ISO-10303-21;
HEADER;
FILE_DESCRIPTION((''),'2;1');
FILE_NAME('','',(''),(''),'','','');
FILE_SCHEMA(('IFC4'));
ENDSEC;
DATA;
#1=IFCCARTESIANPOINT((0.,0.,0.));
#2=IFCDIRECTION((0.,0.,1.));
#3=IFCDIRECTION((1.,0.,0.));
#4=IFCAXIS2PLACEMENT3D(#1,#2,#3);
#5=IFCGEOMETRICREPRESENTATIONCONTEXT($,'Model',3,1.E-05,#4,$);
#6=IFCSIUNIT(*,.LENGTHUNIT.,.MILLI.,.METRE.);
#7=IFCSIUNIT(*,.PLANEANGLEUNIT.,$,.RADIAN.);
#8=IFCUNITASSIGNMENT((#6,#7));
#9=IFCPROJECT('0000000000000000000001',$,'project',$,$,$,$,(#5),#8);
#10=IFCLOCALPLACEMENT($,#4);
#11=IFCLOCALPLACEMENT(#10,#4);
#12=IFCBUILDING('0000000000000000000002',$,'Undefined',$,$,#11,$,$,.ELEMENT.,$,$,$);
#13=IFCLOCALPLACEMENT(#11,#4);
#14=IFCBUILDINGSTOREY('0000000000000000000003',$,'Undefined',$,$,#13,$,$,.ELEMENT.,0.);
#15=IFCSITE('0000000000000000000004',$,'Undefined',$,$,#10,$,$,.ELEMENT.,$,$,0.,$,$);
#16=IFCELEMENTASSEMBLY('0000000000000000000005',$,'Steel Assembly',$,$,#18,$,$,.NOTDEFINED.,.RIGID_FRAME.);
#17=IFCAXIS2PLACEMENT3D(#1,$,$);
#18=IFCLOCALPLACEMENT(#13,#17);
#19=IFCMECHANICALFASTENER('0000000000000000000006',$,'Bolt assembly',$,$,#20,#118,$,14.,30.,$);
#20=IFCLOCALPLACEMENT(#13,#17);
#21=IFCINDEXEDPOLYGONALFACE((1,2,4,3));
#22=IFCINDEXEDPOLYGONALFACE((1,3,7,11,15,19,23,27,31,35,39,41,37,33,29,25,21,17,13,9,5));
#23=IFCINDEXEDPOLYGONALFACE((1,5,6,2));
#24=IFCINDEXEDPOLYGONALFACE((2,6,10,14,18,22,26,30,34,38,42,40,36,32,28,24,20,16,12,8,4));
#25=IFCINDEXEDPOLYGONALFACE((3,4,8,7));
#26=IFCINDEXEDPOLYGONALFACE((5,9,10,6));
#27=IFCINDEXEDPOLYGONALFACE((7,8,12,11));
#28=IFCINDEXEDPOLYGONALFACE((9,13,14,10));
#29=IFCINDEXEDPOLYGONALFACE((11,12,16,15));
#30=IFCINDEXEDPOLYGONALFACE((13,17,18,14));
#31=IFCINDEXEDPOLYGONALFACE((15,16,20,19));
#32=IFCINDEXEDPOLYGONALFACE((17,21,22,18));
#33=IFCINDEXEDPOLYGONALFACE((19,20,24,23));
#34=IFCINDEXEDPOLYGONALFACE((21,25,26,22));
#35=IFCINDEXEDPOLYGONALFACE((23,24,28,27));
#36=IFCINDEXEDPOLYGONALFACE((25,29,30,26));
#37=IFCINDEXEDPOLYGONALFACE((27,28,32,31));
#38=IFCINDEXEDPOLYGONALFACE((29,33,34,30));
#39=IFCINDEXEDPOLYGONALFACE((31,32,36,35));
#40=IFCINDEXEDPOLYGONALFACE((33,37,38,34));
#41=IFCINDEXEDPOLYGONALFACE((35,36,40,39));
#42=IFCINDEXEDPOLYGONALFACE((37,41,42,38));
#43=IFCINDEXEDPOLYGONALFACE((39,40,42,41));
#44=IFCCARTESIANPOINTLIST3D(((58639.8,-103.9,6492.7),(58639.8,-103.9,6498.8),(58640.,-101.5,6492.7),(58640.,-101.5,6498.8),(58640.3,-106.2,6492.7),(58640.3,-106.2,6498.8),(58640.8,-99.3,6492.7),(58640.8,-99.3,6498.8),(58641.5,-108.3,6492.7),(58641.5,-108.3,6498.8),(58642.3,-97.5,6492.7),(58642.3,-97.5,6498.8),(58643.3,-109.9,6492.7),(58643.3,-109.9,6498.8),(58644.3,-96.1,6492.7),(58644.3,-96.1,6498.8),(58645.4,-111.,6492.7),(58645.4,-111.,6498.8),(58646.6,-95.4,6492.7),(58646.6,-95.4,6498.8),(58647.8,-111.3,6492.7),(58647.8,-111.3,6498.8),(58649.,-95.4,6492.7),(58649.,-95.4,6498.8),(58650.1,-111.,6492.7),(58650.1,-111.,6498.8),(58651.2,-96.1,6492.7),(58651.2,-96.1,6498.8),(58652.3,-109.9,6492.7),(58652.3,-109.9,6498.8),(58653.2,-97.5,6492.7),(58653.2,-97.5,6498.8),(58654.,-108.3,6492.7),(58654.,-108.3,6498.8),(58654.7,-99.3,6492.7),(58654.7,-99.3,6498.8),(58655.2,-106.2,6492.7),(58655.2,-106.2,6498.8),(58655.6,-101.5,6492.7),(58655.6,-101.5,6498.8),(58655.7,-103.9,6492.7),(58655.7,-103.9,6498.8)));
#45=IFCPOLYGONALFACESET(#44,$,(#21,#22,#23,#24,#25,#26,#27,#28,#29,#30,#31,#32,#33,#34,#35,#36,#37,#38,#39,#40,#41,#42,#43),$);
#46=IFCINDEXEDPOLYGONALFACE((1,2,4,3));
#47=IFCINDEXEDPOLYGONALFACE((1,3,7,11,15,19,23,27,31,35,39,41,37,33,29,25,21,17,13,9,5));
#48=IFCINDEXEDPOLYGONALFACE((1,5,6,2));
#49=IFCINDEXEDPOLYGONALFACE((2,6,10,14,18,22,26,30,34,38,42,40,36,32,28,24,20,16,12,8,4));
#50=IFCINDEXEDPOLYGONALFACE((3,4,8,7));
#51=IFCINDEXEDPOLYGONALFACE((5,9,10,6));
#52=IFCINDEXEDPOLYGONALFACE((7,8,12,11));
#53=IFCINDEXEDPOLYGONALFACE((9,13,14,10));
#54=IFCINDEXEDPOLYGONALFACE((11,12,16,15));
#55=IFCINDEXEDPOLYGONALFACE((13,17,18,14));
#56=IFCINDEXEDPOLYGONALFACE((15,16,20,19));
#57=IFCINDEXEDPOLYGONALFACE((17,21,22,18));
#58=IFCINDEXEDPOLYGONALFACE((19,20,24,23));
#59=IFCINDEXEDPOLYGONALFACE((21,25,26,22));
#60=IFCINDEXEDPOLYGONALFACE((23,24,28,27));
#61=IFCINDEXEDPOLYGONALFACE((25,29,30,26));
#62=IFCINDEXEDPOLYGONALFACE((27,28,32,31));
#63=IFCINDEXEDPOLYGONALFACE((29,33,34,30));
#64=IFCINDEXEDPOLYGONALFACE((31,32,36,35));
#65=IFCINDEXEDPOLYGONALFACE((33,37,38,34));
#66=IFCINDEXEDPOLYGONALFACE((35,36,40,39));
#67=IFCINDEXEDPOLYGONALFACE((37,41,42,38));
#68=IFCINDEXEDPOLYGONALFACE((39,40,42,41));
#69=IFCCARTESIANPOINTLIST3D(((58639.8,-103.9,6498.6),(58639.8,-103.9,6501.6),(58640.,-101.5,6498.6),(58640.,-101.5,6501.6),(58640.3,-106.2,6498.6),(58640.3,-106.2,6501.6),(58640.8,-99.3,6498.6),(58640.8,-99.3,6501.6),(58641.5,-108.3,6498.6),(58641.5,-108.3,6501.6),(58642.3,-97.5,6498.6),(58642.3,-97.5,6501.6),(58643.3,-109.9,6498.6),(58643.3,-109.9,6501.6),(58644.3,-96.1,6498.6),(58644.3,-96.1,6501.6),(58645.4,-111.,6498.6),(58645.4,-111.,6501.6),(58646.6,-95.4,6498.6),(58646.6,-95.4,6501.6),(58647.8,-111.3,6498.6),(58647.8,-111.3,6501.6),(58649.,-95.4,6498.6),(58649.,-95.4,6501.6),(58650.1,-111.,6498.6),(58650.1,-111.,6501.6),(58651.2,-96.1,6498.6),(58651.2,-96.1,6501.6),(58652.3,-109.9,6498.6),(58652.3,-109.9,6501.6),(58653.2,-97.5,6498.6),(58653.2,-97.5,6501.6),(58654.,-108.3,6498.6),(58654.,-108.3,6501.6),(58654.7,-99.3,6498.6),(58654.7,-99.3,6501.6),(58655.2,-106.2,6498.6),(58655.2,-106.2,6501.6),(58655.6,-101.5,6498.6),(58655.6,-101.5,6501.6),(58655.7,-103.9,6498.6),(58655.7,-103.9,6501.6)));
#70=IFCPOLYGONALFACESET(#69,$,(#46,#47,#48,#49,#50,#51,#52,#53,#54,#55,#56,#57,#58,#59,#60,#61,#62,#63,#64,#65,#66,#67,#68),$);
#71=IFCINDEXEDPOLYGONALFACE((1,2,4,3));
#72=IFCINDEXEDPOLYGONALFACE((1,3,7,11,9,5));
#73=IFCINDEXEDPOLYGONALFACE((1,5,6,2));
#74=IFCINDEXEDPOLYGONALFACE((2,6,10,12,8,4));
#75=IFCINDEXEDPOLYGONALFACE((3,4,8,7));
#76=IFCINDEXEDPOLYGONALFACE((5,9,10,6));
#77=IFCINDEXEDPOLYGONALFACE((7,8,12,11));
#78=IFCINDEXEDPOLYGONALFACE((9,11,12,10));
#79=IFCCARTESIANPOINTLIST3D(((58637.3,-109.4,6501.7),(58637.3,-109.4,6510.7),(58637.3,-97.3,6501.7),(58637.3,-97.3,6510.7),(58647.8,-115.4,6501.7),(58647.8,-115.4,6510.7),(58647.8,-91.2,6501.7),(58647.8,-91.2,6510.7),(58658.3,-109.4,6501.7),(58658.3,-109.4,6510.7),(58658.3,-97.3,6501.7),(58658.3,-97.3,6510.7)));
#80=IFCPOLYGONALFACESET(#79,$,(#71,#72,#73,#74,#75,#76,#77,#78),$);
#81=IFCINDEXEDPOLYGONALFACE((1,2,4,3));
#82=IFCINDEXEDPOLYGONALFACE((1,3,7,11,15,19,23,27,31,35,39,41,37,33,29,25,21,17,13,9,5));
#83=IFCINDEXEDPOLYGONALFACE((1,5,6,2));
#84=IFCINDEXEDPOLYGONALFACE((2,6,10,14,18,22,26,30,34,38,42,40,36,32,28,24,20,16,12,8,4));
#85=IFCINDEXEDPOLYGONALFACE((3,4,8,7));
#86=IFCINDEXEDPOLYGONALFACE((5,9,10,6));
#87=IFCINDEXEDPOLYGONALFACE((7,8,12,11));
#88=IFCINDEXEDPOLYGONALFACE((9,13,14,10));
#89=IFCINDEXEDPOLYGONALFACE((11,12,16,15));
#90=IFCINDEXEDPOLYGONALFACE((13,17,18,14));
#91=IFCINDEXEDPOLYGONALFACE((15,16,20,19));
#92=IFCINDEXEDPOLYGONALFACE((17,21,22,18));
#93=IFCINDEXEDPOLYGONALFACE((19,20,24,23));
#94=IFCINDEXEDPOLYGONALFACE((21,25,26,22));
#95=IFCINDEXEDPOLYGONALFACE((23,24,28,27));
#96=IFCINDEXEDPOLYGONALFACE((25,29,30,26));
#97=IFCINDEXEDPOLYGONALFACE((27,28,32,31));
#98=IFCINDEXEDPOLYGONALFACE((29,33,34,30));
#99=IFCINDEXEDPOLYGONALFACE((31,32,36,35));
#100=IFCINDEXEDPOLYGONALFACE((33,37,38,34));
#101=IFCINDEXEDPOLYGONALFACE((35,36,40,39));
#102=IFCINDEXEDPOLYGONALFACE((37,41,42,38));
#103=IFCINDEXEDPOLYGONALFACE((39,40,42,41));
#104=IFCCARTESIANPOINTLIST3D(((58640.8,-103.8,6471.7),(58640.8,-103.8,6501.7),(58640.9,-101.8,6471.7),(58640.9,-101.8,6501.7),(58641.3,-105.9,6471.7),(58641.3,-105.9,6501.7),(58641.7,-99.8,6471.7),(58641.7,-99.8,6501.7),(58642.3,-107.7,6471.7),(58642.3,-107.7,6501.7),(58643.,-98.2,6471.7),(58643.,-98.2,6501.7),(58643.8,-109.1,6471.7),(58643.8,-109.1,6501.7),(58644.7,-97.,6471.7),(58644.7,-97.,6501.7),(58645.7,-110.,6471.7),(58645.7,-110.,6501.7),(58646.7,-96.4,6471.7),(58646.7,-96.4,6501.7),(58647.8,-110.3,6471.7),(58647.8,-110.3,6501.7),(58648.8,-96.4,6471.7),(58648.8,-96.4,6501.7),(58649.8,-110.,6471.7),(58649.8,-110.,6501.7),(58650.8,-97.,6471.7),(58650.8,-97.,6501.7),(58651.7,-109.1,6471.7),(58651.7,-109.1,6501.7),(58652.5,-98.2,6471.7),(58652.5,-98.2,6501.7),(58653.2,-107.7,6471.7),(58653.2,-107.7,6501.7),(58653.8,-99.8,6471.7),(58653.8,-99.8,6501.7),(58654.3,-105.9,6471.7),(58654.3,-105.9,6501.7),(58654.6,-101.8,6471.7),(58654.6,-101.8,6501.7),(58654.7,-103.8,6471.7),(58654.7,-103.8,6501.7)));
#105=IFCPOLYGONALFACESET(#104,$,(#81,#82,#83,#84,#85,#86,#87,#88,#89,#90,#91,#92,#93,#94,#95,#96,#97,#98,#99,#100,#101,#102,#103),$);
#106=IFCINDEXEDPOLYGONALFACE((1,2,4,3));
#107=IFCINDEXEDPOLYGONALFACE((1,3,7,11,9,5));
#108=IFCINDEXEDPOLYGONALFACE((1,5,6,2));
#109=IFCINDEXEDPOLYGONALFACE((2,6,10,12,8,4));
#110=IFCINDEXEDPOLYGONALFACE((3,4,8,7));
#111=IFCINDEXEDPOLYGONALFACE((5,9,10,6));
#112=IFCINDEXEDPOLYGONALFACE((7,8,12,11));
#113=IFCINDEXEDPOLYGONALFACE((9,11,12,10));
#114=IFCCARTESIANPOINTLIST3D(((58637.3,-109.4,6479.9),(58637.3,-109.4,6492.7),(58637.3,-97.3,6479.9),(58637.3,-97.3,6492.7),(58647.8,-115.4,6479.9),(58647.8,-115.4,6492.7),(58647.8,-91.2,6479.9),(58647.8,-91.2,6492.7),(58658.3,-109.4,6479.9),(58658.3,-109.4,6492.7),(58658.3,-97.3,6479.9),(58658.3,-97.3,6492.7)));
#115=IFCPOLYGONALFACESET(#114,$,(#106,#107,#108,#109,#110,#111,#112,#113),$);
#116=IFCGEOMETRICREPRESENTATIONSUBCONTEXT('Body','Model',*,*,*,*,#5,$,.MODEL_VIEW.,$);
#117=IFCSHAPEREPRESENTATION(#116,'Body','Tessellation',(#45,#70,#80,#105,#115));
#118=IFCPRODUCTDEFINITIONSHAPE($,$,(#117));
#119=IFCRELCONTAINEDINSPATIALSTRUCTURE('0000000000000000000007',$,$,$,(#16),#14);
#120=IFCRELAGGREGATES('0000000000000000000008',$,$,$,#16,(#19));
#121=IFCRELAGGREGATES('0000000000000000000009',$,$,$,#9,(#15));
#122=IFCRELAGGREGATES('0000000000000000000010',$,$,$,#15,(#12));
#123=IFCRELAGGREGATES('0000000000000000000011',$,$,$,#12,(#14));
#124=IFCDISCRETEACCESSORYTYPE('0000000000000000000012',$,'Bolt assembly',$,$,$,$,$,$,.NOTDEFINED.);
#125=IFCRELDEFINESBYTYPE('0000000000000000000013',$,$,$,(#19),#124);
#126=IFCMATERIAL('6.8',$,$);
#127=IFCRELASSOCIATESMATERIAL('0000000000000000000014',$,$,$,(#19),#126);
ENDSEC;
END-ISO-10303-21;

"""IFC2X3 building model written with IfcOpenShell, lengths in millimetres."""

from ifc_helpers import new_model, si_unit, frame, origin_with_axes, origin_2d_with_axis, place, context, subcontext, project, spatial, polyline, circle, outline, extrude, source, transform, mapped, material, type_object, element, aggregate, save


model = new_model("IFC2X3")

# Units and contexts
model_context = context("Model", 3, precision=1e-05, world=origin_with_axes())
body_context = subcontext(model_context, "Body", "Model", "MODEL_VIEW")
ifc_project = project(units=[si_unit("LENGTHUNIT", "METRE", prefix="MILLI"), si_unit("PLANEANGLEUNIT", "RADIAN")], contexts=[model_context])

# Site, building, storey
site_placement = place(None, origin_with_axes())
site = spatial("IfcSite", under=ifc_project, at=site_placement, Name="Undefined", CompositionType="ELEMENT", RefElevation=0.0)
building_placement = place(site_placement, origin_with_axes())
building = spatial("IfcBuilding", under=site, at=building_placement, Name="Undefined", CompositionType="ELEMENT")
storey_placement = place(building_placement, origin_with_axes())
storey = spatial("IfcBuildingStorey", under=building, at=storey_placement, Name="Undefined", CompositionType="ELEMENT", Elevation=0.0)

# Element assembly
assembly_1_placement = place(storey_placement, origin_with_axes())
assembly_1 = element("IfcElementAssembly", 1, at=assembly_1_placement, inside=storey, Name="Steel Assembly", AssemblyPlace="NOTDEFINED", PredefinedType="RIGID_FRAME")

# Shared definitions
ifc_material_1 = material(Name="6.8")
discrete_accessory_type_1 = type_object("IfcDiscreteAccessoryType", Name="Bolt assembly")

# Mechanical fastener
shared_shape_1 = source(origin_with_axes(), body_context, "Body", "SweptSolid", [
    extrude(circle(Radius=8.0, at=origin_2d_with_axis()), frame((0.0, -0.1, 0.0), z_axis=(0.0, 1.0, 0.0), x_axis=(1.0, 0.0, 0.0)), (0.0, 0.0, 1.0), 6.1),
    extrude(circle(Radius=8.0, at=origin_2d_with_axis()), frame((0.0, -2.9, 0.0), z_axis=(0.0, 1.0, 0.0), x_axis=(1.0, 0.0, 0.0)), (0.0, 0.0, 1.0), 3.0),
    extrude(outline(polyline([(12.1, 0.0), (6.1, 10.5), (-6.1, 10.5), (-12.1, 0.0), (-6.1, -10.5), (6.1, -10.5), (12.1, 0.0)])), frame((0.0, -12.0, 0.0), z_axis=(0.0, 1.0, 0.0), x_axis=(1.0, 0.0, 0.0)), (0.0, 0.0, 1.0), 9.0),
    extrude(circle(Radius=7.0, at=origin_2d_with_axis()), frame((0.0, -3.0, 0.0), z_axis=(0.0, 1.0, 0.0), x_axis=(1.0, 0.0, 0.0)), (0.0, 0.0, 1.0), 30.0),
    extrude(outline(polyline([(12.1, 0.0), (6.1, 10.5), (-6.1, 10.5), (-12.1, 0.0), (-6.1, -10.5), (6.1, -10.5), (12.1, 0.0)])), frame((0.0, 6.0, 0.0), z_axis=(0.0, 1.0, 0.0), x_axis=(1.0, 0.0, 0.0)), (0.0, 0.0, 1.0), 12.8),
])
mechanical_fastener_1_placement = place(assembly_1_placement, frame((58647.8, -103.3, 6498.7), z_axis=(1.0, 0.0, 0.0), x_axis=(0.0, -1.0, 0.0)))
mechanical_fastener_1 = element("IfcMechanicalFastener", 2, at=mechanical_fastener_1_placement, type_object=discrete_accessory_type_1, material=ifc_material_1, Name="Bolt assembly", NominalDiameter=14.0, NominalLength=30.0, context=body_context, shape_type="MappedRepresentation", body=[
    mapped(shared_shape_1, transform((0.0, 0.0, 0.0))),
])
aggregate(assembly_1, [mechanical_fastener_1])

save(model, "model.ifc")
